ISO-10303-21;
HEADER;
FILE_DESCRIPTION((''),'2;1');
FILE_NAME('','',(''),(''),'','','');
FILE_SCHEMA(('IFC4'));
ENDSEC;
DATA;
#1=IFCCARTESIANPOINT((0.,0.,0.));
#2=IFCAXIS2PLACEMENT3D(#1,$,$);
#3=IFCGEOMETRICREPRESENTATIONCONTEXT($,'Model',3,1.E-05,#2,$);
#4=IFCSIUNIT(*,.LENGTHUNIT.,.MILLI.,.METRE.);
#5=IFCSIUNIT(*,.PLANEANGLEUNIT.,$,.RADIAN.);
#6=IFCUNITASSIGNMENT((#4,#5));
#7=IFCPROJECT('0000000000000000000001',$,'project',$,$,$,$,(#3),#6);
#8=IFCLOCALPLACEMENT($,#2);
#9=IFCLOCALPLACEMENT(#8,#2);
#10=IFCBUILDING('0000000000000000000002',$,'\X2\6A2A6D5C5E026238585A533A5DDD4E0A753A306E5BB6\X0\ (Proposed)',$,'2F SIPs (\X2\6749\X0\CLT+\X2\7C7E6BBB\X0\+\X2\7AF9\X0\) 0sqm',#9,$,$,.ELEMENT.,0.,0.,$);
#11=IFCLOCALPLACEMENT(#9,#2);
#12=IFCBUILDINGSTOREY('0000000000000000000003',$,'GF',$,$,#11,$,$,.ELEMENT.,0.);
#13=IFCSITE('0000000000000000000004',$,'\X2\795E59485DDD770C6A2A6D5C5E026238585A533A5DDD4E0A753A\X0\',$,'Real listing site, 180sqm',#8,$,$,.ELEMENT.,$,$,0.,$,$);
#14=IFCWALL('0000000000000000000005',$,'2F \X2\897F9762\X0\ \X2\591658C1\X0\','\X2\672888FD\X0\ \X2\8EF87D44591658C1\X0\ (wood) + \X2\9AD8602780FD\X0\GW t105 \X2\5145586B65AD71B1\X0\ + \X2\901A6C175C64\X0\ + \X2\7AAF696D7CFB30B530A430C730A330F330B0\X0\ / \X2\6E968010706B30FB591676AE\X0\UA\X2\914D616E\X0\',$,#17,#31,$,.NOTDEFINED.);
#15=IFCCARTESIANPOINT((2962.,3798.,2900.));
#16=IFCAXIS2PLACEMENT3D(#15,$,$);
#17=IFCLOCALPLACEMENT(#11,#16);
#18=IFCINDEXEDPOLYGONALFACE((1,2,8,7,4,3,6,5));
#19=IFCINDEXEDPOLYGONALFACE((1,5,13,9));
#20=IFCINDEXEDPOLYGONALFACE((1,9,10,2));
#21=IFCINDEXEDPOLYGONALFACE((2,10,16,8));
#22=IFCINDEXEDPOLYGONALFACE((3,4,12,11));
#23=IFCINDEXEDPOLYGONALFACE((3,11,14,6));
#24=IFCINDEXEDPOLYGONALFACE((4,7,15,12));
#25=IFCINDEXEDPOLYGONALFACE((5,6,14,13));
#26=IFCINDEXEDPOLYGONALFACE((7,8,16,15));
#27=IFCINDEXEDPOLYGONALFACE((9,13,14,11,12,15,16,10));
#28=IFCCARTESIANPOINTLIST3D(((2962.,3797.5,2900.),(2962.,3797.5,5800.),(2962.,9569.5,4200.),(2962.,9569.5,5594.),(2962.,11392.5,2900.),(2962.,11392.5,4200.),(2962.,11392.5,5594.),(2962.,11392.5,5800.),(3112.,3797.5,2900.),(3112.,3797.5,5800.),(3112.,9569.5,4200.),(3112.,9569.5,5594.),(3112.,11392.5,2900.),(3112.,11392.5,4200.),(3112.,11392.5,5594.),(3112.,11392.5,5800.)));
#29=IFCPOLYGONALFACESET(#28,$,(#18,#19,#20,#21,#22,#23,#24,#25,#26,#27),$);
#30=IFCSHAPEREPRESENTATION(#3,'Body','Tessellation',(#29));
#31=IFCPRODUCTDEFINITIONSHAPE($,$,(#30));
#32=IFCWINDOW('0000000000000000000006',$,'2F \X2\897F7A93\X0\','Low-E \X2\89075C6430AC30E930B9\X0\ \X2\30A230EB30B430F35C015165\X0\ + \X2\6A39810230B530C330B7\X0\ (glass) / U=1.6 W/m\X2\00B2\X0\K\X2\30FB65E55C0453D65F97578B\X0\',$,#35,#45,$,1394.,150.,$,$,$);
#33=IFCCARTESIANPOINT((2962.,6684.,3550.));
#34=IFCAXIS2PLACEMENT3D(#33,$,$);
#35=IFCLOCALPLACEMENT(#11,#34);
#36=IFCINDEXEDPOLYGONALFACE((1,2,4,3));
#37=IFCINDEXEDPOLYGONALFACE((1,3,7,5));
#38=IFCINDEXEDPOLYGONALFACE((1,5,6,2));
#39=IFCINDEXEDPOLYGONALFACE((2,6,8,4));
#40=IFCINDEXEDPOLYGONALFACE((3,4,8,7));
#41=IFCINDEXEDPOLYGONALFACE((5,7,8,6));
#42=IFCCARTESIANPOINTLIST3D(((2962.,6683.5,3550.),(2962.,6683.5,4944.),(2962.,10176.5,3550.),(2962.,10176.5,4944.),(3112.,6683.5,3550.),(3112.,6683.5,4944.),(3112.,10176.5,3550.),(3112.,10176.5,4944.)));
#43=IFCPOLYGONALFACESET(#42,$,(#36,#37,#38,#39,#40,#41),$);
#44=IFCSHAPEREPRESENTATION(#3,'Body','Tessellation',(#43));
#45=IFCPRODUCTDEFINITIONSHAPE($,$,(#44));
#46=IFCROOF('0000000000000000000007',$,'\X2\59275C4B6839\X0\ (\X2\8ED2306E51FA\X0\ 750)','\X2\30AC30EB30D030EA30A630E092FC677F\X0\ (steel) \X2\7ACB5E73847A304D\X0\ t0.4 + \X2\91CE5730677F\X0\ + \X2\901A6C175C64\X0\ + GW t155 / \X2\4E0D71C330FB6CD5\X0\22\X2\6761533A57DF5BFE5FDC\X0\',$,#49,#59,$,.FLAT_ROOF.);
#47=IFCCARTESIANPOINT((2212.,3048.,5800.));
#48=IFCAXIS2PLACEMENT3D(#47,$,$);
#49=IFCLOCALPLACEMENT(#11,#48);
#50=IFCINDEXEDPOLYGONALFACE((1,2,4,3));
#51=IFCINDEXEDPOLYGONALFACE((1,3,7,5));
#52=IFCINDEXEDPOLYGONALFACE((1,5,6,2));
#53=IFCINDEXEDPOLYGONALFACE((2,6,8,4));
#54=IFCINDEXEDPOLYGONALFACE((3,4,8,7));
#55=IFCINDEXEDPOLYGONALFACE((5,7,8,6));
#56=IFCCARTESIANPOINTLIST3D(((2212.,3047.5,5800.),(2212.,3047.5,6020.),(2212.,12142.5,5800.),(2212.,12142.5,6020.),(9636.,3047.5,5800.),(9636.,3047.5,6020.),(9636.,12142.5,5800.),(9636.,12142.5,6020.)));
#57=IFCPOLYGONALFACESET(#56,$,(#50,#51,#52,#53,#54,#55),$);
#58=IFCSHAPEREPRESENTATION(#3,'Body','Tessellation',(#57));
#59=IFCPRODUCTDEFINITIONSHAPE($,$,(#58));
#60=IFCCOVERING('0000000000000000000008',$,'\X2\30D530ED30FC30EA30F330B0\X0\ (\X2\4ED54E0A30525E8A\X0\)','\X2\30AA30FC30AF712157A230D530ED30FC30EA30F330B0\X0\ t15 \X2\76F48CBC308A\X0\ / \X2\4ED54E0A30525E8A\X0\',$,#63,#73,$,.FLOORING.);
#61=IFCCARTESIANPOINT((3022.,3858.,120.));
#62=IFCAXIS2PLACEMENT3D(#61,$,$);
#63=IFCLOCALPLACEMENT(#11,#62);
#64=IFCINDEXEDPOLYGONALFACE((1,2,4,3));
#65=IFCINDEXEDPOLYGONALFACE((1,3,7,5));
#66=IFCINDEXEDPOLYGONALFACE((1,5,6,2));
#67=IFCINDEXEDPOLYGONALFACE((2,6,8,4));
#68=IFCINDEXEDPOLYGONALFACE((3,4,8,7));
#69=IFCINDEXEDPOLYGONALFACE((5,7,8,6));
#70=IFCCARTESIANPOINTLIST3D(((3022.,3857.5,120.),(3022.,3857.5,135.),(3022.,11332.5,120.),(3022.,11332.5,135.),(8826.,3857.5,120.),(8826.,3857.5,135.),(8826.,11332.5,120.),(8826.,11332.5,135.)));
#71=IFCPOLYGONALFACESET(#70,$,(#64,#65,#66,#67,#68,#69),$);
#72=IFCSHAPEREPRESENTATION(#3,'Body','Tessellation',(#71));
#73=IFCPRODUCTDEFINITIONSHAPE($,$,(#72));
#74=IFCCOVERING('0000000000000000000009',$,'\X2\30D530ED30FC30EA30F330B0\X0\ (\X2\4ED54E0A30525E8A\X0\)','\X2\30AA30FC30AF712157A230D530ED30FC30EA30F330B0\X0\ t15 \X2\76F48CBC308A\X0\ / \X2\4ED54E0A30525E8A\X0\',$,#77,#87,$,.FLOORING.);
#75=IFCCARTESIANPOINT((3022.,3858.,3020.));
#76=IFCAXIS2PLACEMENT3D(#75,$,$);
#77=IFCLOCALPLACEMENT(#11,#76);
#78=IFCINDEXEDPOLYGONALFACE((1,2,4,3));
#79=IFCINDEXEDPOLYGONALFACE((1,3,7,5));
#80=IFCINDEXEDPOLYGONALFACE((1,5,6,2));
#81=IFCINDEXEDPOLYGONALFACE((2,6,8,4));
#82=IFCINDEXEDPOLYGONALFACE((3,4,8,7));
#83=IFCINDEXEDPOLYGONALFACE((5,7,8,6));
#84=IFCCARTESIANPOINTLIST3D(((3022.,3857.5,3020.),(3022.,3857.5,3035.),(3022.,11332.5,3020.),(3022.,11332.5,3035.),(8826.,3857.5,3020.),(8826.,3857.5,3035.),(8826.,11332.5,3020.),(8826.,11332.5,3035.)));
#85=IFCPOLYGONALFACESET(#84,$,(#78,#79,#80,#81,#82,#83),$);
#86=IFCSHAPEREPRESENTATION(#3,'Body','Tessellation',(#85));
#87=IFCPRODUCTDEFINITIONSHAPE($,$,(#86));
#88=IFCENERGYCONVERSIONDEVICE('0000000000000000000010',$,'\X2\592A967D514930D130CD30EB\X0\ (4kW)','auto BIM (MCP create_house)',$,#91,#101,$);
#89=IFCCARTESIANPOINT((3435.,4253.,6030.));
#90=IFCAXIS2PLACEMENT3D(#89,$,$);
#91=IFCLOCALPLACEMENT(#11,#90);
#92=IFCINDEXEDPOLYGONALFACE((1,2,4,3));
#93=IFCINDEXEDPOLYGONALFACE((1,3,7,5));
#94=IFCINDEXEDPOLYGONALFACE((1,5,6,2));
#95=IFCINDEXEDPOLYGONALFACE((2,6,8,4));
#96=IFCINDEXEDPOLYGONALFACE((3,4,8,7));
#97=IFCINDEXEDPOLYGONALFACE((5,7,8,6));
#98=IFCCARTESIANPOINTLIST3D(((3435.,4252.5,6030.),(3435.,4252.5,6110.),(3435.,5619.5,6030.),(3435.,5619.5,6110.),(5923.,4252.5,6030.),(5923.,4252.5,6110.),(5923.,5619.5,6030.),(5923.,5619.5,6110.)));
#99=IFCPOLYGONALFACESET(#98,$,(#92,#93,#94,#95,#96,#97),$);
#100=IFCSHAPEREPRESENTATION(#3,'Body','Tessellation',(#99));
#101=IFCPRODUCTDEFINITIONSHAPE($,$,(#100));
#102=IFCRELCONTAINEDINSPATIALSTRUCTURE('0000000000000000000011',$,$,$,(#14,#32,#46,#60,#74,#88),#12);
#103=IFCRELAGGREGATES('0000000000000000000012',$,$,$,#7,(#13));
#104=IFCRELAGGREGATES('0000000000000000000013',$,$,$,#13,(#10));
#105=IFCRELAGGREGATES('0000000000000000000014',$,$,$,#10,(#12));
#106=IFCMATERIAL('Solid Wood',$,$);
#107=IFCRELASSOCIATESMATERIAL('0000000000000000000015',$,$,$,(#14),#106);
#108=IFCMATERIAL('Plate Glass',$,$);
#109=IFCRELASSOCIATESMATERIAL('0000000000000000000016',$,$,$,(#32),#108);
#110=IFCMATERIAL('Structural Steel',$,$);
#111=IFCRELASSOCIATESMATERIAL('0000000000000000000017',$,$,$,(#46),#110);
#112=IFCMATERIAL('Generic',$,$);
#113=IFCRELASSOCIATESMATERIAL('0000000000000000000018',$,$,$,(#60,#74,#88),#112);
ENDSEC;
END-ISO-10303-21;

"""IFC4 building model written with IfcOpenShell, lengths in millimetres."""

from ifc_helpers import new_model, si_unit, frame, frame_2d, origin, place, context, project, spatial, rectangle, extrude, material, element, fill, save


model = new_model("IFC4")

# Units and contexts
model_context = context("Model", 3, precision=1e-05, world=origin())
ifc_project = project(units=[si_unit("LENGTHUNIT", "METRE", prefix="MILLI"), si_unit("PLANEANGLEUNIT", "RADIAN")], contexts=[model_context])

# Site, building, storey
site_placement = place(None, origin())
site = spatial("IfcSite", under=ifc_project, at=site_placement, Name="神奈川県横浜市戸塚区川上町", ObjectType="Real listing site, 180sqm", CompositionType="ELEMENT", RefElevation=0.0)
building_placement = place(site_placement, origin())
building = spatial("IfcBuilding", under=site, at=building_placement, Name="横浜市戸塚区川上町の家 (Proposed)", ObjectType="2F SIPs (杉CLT+籾殻+竹) 0sqm", CompositionType="ELEMENT", ElevationOfRefHeight=0.0, ElevationOfTerrain=0.0)
storey_placement = place(building_placement, origin())
storey = spatial("IfcBuildingStorey", under=building, at=storey_placement, Name="GF", CompositionType="ELEMENT", Elevation=0.0)

# Shared definitions
ifc_material_1 = material(Name="Solid Wood")

# Shared definitions
ifc_material_2 = material(Name="Plate Glass")

# Wall, opening, window
wall_1_placement = place(storey_placement, frame((2962.0, 3798.0, 2900.0)))
wall_1 = element("IfcWall", 1, at=wall_1_placement, inside=storey, material=ifc_material_1, Name="2F 西面 外壁", Description="木製 軸組外壁 (wood) + 高性能GW t105 充填断熱 + 通気層 + 窯業系サイディング / 準耐火・外皮UA配慮", PredefinedType="NOTDEFINED", context=model_context, shape_type="SweptSolid", body=[
    extrude(rectangle(XDim=150.0, YDim=7595.0, at=frame_2d((75.0, 3797.0))), frame((2962.0, 3798.0, 2900.0)), (0.0, 0.0, 1.0), 2900.0),
])
opening_1_placement = place(storey_placement, frame((2962.0, 6684.0, 3550.0)))
opening_1 = element("IfcOpeningElement", 2, at=opening_1_placement, cuts=wall_1, PredefinedType="NOTDEFINED", context=model_context, shape_type="SweptSolid", body=[
    extrude(rectangle(XDim=150.0, YDim=3493.0, at=frame_2d((75.0, 1746.0))), frame((2962.0, 6684.0, 3550.0)), (0.0, 0.0, 1.0), 1394.0),
])
window_1_placement = place(storey_placement, frame((2962.0, 6684.0, 3550.0)))
window_1 = element("IfcWindow", 3, at=window_1_placement, inside=storey, material=ifc_material_2, Name="2F 西窓", Description="Low-E 複層ガラス アルゴン封入 + 樹脂サッシ (glass) / U=1.6 W/m²K・日射取得型", OverallHeight=1394.0, OverallWidth=150.0, context=model_context, shape_type="SweptSolid", body=[
    extrude(rectangle(XDim=150.0, YDim=3493.0, at=frame_2d((75.0, 1746.0))), frame((2962.0, 6684.0, 3550.0)), (0.0, 0.0, 1.0), 1394.0),
])
fill(opening_1, window_1)

# Roof
ifc_material_3 = material(Name="Structural Steel")
roof_placement = place(storey_placement, frame((2212.0, 3048.0, 5800.0)))
element("IfcRoof", 4, at=roof_placement, inside=storey, material=ifc_material_3, Name="大屋根 (軒の出 750)", Description="ガルバリウム鋼板 (steel) 立平葺き t0.4 + 野地板 + 通気層 + GW t155 / 不燃・法22条区域対応", PredefinedType="FLAT_ROOF", context=model_context, shape_type="SweptSolid", body=[
    extrude(rectangle(XDim=7424.0, YDim=9095.0, at=frame_2d((3712.0, 4547.0))), frame((2212.0, 3048.0, 5800.0)), (0.0, 0.0, 1.0), 220.0),
])

# Coverings
ifc_material_4 = material(Name="Generic")
covering_1_placement = place(storey_placement, frame((3022.0, 3858.0, 120.0)))
element("IfcCovering", 5, at=covering_1_placement, inside=storey, material=ifc_material_4, Name="フローリング (仕上げ床)", Description="オーク無垢フローリング t15 直貼り / 仕上げ床", PredefinedType="FLOORING", context=model_context, shape_type="SweptSolid", body=[
    extrude(rectangle(XDim=5804.0, YDim=7475.0, at=frame_2d((2902.0, 3737.0))), frame((3022.0, 3858.0, 120.0)), (0.0, 0.0, 1.0), 15.0),
])
covering_2_placement = place(storey_placement, frame((3022.0, 3858.0, 3020.0)))
element("IfcCovering", 6, at=covering_2_placement, inside=storey, material=ifc_material_4, Name="フローリング (仕上げ床)", Description="オーク無垢フローリング t15 直貼り / 仕上げ床", PredefinedType="FLOORING", context=model_context, shape_type="SweptSolid", body=[
    extrude(rectangle(XDim=5804.0, YDim=7475.0, at=frame_2d((2902.0, 3737.0))), frame((3022.0, 3858.0, 3020.0)), (0.0, 0.0, 1.0), 15.0),
])

# Energy conversion device
energy_conversion_device_placement = place(storey_placement, frame((3435.0, 4253.0, 6030.0)))
element("IfcEnergyConversionDevice", 7, at=energy_conversion_device_placement, inside=storey, material=ifc_material_4, Name="太陽光パネル (4kW)", Description="auto BIM (MCP create_house)", context=model_context, shape_type="SweptSolid", body=[
    extrude(rectangle(XDim=2488.0, YDim=1367.0, at=frame_2d((1244.0, 683.0))), frame((3435.0, 4253.0, 6030.0)), (0.0, 0.0, 1.0), 80.0),
])

save(model, "model.ifc")
